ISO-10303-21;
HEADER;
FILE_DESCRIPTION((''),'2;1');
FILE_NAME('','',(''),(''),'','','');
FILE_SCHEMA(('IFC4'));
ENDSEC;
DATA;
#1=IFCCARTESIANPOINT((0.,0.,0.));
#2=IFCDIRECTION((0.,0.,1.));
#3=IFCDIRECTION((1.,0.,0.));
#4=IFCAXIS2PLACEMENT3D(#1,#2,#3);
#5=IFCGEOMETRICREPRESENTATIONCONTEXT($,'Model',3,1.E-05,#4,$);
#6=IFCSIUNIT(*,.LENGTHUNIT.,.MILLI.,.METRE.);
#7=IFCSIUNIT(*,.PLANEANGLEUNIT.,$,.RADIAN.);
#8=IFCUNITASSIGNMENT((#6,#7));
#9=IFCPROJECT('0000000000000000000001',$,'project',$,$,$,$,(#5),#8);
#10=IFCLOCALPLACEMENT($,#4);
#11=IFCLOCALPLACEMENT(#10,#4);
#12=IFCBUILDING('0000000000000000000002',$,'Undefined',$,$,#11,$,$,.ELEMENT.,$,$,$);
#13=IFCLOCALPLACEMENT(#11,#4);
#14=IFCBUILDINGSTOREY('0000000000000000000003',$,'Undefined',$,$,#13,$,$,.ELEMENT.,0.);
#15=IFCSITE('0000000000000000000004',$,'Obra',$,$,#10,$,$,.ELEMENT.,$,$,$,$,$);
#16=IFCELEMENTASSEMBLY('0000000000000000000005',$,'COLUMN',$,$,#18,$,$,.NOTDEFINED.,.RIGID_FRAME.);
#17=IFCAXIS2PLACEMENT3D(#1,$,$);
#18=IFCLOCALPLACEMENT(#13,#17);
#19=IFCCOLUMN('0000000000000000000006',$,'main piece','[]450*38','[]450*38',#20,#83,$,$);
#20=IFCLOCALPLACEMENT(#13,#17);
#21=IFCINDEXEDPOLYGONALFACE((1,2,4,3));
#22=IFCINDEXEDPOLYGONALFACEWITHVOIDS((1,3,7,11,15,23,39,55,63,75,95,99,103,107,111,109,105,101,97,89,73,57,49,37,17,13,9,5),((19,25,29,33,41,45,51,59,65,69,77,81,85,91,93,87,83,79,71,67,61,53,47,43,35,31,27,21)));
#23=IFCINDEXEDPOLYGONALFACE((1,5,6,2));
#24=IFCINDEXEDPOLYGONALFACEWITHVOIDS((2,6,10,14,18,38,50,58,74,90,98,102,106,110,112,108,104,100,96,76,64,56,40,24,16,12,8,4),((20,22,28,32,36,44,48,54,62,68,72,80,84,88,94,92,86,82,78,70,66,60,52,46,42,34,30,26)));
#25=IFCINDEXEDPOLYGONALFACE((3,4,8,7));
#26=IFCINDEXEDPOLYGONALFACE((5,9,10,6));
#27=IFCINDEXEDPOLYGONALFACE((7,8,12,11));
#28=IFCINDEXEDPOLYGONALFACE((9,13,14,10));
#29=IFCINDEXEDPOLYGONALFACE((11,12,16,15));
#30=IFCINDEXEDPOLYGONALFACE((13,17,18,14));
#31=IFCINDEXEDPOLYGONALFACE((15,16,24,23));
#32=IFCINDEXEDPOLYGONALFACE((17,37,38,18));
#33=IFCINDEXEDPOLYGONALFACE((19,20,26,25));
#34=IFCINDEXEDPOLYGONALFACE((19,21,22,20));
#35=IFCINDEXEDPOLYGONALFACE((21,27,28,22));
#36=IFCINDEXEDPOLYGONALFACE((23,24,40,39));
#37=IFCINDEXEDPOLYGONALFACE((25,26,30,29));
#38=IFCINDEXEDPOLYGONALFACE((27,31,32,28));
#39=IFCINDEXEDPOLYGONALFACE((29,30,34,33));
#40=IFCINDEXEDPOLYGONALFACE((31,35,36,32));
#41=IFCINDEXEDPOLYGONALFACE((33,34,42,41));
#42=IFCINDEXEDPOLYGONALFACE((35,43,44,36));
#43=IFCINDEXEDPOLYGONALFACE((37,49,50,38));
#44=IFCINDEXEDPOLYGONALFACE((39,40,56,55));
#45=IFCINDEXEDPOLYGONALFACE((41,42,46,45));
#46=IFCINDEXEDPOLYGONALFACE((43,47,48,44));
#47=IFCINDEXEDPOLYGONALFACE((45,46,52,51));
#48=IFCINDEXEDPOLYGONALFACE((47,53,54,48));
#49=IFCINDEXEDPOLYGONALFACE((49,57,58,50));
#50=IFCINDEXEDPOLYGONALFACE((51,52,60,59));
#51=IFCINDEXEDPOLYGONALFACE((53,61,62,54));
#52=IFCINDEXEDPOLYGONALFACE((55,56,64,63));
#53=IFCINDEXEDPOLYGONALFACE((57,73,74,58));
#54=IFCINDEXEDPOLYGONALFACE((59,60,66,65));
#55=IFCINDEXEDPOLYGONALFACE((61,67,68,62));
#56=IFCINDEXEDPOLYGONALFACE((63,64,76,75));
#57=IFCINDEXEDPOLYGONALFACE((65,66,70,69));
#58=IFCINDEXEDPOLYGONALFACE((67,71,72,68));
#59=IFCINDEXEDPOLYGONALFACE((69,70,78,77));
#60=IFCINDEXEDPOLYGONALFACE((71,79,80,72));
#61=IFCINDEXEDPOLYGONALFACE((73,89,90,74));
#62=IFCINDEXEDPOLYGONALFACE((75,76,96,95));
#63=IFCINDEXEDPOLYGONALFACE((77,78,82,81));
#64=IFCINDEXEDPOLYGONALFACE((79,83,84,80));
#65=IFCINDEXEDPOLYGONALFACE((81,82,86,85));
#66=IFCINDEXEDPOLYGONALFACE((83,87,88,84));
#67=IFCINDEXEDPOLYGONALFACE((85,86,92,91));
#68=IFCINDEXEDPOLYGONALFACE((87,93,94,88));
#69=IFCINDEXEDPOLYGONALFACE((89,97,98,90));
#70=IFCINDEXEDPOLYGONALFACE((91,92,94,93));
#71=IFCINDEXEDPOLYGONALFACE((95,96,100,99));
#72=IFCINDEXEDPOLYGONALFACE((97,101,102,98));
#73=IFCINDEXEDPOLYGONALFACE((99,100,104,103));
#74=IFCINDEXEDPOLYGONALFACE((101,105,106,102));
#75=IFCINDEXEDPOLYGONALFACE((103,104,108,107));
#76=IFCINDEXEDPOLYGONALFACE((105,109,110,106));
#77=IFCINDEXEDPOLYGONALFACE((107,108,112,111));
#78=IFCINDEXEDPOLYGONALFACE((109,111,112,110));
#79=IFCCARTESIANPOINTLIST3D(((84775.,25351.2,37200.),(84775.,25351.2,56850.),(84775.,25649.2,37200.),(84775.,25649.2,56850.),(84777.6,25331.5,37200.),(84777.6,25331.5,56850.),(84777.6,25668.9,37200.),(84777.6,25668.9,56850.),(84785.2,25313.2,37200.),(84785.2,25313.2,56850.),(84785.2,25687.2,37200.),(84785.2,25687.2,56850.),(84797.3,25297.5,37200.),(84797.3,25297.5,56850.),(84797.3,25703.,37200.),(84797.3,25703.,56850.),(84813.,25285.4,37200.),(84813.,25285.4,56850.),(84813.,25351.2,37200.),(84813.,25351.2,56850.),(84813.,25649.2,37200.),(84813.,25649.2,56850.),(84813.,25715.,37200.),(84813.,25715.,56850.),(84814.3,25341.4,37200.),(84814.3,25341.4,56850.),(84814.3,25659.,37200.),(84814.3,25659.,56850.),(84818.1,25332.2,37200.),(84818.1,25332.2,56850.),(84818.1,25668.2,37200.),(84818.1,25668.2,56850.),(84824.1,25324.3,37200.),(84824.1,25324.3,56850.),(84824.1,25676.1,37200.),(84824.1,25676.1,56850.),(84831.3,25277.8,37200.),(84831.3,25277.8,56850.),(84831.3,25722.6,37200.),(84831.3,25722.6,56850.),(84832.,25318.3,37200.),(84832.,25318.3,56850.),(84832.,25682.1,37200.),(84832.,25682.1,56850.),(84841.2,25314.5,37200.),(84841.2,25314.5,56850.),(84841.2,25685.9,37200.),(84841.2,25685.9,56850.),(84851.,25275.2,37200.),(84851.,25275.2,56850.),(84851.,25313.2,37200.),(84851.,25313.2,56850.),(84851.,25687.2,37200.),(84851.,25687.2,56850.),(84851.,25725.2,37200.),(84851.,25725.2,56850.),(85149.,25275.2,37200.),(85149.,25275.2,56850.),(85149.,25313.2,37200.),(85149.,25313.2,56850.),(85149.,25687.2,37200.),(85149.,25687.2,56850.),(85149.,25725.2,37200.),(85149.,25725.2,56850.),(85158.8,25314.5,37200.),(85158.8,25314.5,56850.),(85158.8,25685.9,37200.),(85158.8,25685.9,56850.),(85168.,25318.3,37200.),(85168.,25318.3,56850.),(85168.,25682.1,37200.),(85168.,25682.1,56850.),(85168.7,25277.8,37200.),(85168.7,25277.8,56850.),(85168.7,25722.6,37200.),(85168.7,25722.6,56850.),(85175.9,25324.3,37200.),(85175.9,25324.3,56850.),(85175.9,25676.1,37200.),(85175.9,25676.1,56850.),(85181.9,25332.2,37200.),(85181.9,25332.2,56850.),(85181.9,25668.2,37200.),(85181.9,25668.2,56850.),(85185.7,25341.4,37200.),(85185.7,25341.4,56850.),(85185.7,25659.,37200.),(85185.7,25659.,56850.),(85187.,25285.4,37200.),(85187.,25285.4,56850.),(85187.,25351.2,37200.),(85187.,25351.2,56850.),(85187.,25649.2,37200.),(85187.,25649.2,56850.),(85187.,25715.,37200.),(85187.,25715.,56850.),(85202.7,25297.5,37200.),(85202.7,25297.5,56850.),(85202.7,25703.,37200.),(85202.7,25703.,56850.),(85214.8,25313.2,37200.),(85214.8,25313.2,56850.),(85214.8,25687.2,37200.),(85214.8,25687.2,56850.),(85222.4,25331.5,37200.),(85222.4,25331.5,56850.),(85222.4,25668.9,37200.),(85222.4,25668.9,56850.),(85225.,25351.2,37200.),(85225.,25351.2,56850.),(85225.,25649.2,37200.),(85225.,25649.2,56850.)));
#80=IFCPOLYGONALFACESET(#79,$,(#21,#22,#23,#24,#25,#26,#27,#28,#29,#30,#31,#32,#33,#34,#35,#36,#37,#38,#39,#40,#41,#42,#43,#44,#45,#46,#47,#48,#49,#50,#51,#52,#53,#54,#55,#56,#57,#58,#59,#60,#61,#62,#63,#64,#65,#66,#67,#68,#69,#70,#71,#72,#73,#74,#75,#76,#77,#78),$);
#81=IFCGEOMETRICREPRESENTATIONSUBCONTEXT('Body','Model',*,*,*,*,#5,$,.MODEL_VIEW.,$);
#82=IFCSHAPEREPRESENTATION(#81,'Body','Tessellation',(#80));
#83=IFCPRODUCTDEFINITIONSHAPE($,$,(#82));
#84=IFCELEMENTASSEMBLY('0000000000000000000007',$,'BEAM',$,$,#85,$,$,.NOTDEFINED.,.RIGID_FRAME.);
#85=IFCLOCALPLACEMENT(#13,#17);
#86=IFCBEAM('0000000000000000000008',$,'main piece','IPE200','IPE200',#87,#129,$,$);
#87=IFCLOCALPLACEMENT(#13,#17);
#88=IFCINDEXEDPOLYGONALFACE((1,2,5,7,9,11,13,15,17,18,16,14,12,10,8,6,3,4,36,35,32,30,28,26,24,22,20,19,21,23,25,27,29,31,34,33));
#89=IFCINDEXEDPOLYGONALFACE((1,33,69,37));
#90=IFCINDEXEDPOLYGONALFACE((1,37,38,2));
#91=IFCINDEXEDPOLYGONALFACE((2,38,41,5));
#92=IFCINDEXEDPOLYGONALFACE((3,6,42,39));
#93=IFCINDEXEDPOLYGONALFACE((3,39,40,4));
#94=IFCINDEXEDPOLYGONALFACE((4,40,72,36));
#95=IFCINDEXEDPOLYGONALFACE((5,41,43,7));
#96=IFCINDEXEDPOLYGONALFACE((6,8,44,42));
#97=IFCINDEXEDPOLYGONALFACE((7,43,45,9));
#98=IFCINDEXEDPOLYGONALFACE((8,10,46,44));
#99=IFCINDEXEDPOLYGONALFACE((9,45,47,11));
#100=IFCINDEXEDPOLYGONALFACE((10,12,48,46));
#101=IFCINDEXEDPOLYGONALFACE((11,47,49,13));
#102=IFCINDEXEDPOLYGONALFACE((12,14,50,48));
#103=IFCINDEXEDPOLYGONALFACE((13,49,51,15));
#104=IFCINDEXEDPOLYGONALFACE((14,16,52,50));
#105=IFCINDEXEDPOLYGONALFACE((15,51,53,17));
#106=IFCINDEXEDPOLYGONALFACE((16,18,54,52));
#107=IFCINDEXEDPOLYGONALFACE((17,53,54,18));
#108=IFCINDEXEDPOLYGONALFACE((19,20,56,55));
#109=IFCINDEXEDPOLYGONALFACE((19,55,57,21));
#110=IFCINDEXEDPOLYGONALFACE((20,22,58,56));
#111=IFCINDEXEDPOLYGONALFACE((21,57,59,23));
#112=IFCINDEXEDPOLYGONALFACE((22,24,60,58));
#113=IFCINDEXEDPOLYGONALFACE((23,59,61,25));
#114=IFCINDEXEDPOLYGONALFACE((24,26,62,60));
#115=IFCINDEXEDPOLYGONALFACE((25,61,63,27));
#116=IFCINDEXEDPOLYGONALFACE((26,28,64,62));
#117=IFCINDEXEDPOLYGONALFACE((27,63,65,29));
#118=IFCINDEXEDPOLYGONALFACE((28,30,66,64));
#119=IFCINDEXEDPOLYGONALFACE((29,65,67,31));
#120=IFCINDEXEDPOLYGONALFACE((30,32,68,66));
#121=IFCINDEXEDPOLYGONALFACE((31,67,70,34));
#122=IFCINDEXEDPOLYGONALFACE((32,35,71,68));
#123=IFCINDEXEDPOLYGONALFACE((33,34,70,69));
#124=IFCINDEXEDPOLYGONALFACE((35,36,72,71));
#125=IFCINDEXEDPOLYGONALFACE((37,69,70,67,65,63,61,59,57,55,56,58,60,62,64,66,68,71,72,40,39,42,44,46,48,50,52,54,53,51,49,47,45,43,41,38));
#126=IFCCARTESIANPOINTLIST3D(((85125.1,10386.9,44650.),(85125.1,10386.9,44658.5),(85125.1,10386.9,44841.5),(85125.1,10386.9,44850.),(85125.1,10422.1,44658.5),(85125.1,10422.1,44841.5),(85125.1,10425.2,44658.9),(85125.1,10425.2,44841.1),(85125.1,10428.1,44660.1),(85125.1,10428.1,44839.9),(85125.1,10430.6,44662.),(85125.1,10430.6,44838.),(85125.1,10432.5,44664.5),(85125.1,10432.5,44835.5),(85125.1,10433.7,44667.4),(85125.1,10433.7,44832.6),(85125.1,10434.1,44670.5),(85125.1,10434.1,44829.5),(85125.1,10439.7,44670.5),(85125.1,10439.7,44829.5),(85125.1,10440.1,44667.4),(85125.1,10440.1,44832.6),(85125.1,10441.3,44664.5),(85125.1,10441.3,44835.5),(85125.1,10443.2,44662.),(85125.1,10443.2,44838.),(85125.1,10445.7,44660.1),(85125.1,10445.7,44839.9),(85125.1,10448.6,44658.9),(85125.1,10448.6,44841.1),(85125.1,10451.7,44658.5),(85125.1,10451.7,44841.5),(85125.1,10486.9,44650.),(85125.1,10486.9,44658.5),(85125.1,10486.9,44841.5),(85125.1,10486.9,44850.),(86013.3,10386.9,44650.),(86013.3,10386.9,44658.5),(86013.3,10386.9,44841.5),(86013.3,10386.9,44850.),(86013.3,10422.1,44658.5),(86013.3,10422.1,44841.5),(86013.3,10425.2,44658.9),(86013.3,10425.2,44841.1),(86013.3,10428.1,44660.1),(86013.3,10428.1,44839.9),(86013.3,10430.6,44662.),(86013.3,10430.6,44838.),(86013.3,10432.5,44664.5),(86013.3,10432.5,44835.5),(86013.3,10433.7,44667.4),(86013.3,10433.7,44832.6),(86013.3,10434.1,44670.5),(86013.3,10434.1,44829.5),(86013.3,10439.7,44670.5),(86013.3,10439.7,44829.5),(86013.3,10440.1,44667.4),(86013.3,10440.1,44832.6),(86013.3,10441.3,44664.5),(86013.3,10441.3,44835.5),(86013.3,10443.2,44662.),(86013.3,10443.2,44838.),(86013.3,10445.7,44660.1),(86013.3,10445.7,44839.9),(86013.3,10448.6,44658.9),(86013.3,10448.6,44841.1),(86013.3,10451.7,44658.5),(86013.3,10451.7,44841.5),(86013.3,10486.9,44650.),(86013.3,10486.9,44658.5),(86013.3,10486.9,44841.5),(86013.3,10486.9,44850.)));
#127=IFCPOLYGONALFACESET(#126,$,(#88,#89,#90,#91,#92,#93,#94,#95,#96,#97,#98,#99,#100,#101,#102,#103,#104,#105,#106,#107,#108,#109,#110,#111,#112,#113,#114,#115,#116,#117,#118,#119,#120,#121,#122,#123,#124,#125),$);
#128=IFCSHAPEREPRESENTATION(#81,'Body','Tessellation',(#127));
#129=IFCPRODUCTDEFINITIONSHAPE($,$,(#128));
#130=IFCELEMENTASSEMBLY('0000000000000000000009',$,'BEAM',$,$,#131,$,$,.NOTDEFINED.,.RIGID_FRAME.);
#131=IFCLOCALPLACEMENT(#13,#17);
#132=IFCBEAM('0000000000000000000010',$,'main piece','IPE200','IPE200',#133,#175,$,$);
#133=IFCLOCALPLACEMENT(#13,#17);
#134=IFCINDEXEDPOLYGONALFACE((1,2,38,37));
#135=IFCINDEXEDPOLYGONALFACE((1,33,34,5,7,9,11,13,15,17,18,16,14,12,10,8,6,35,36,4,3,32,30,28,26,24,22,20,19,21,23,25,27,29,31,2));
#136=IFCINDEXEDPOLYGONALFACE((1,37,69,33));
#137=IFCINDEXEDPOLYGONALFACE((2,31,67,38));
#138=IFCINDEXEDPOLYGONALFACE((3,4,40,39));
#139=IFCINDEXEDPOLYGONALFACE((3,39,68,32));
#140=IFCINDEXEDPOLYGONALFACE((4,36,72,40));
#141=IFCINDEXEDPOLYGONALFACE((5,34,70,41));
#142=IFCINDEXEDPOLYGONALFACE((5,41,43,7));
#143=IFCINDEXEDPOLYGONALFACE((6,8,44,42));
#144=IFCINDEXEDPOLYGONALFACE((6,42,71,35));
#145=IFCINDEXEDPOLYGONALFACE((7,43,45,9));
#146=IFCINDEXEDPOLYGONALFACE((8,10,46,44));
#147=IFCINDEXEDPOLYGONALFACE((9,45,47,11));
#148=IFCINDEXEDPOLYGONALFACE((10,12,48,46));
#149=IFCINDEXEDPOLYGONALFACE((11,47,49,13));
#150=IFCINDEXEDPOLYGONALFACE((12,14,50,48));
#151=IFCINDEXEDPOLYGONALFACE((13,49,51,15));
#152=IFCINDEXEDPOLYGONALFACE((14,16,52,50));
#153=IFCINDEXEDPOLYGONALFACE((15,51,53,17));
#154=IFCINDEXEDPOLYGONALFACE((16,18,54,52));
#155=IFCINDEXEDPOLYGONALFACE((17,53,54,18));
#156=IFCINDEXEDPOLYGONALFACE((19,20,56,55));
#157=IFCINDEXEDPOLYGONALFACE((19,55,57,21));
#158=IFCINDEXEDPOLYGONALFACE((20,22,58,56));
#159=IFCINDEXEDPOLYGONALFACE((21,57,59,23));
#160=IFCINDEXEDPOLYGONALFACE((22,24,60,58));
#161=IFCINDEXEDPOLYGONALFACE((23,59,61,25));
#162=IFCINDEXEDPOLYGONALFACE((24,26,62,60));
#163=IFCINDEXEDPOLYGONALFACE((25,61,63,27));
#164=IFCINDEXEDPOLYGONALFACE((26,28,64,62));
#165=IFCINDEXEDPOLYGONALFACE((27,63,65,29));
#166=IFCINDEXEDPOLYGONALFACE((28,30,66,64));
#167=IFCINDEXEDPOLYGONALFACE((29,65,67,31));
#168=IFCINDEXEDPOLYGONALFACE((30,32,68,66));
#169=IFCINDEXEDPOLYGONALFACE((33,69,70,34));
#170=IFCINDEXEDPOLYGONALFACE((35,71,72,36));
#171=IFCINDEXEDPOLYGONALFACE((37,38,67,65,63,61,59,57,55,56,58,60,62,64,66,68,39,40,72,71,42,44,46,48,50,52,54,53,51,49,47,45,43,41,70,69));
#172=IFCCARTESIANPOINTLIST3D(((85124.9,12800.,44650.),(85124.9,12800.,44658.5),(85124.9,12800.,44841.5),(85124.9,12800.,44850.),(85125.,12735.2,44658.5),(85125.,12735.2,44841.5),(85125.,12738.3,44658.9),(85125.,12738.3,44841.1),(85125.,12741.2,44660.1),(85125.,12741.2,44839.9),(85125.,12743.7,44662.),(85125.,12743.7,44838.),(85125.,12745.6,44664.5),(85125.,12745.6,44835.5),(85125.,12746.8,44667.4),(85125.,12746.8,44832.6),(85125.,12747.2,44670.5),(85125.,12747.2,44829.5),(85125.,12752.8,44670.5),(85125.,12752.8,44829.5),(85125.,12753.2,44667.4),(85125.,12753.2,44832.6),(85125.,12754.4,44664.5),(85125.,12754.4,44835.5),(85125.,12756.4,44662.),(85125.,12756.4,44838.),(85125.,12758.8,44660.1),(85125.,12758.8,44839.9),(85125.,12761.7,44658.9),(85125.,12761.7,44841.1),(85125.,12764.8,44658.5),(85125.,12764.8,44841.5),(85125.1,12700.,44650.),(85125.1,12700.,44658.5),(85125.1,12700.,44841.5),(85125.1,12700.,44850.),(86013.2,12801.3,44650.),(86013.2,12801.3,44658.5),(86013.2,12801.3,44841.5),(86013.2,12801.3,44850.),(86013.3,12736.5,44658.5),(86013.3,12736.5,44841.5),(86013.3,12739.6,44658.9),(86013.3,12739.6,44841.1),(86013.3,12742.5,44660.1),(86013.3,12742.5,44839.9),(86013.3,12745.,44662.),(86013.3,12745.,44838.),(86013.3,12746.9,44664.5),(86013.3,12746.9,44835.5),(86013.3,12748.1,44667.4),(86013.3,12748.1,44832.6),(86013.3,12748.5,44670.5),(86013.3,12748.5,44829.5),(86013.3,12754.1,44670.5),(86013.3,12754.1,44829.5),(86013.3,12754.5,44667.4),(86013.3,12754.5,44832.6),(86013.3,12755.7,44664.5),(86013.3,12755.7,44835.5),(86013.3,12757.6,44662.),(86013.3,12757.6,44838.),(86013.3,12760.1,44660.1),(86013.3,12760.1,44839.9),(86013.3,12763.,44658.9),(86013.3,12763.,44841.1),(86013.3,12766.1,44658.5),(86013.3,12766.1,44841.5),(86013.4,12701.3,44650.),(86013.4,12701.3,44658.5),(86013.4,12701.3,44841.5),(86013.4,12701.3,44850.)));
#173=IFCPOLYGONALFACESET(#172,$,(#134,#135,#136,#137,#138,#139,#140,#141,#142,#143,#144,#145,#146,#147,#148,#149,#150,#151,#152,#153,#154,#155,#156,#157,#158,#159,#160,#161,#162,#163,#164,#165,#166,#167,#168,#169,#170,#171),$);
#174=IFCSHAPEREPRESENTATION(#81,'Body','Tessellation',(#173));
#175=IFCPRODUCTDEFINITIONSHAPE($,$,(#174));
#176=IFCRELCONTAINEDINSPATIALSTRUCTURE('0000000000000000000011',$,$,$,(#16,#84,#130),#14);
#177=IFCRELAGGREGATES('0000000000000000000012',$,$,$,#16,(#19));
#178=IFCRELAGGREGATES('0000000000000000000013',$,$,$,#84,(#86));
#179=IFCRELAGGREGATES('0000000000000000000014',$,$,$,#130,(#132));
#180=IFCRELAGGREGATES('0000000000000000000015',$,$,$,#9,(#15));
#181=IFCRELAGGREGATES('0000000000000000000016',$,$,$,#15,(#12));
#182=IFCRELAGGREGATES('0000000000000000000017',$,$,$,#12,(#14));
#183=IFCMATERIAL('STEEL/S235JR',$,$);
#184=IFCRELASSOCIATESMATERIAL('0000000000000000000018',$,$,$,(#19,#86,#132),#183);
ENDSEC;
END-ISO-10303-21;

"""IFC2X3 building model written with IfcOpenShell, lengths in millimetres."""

from ifc_helpers import new_model, si_unit, frame, origin_with_axes, origin_2d_with_axis, place, context, subcontext, project, spatial, hollow_rectangle, i_section, extrude, material, element, aggregate, save


model = new_model("IFC2X3")

# Units and contexts
model_context = context("Model", 3, precision=1e-05, world=origin_with_axes())
body_context = subcontext(model_context, "Body", "Model", "MODEL_VIEW")
ifc_project = project(units=[si_unit("LENGTHUNIT", "METRE", prefix="MILLI"), si_unit("PLANEANGLEUNIT", "RADIAN")], contexts=[model_context])

# Site, building, storey
site_placement = place(None, origin_with_axes())
site = spatial("IfcSite", under=ifc_project, at=site_placement, Name="Obra", CompositionType="ELEMENT")
building_placement = place(site_placement, origin_with_axes())
building = spatial("IfcBuilding", under=site, at=building_placement, Name="Undefined", CompositionType="ELEMENT")
storey_placement = place(building_placement, origin_with_axes())
storey = spatial("IfcBuildingStorey", under=building, at=storey_placement, Name="Undefined", CompositionType="ELEMENT", Elevation=0.0)

# Element assembly, column
assembly_1_placement = place(storey_placement, origin_with_axes())
assembly_1 = element("IfcElementAssembly", 1, at=assembly_1_placement, inside=storey, Name="COLUMN", AssemblyPlace="NOTDEFINED", PredefinedType="RIGID_FRAME")
ifc_material = material(Name="STEEL/S235JR")
column_placement = place(assembly_1_placement, frame((85000.0, 25500.2, 37200.0), z_axis=(0.0, 0.0, 1.0), x_axis=(0.0, 1.0, 0.0)))
column = element("IfcColumn", 2, at=column_placement, material=ifc_material, Name="main piece", Description="[]450*38", ObjectType="[]450*38", context=body_context, shape_type="SweptSolid", body=[
    extrude(hollow_rectangle(XDim=450.0, YDim=450.0, WallThickness=38.0, InnerFilletRadius=38.0, OuterFilletRadius=76.0, at=origin_2d_with_axis()), frame((0.0, 0.0, 19650.0), z_axis=(0.0, 0.0, -1.0), x_axis=(0.0, 1.0, 0.0)), (0.0, 0.0, 1.0), 19650.0),
])
aggregate(assembly_1, [column])

# Element assemblies, beams
assembly_2_placement = place(storey_placement, origin_with_axes())
assembly_2 = element("IfcElementAssembly", 3, at=assembly_2_placement, inside=storey, Name="BEAM", AssemblyPlace="NOTDEFINED", PredefinedType="RIGID_FRAME")
beam_1_placement = place(assembly_2_placement, frame((85125.1, 10436.9, 44750.0), z_axis=(0.0, 0.0, 1.0), x_axis=(1.0, 0.0, 0.0)))
beam_1 = element("IfcBeam", 4, at=beam_1_placement, material=ifc_material, Name="main piece", Description="IPE200", ObjectType="IPE200", context=body_context, shape_type="SweptSolid", body=[
    extrude(i_section(OverallWidth=100.0, OverallDepth=200.0, WebThickness=5.6, FlangeThickness=8.5, FilletRadius=12.0, at=origin_2d_with_axis()), frame((888.2, 0.0, 0.0), z_axis=(-1.0, 0.0, 0.0), x_axis=(0.0, -1.0, 0.0)), (0.0, 0.0, 1.0), 888.2),
])
aggregate(assembly_2, [beam_1])
assembly_3_placement = place(storey_placement, origin_with_axes())
assembly_3 = element("IfcElementAssembly", 5, at=assembly_3_placement, inside=storey, Name="BEAM", AssemblyPlace="NOTDEFINED", PredefinedType="RIGID_FRAME")
beam_2_placement = place(assembly_3_placement, frame((85125.0, 12750.0, 44750.0), z_axis=(0.0, 0.0, 1.0), x_axis=(0.999999, 0.001449, 0.0)))
beam_2 = element("IfcBeam", 6, at=beam_2_placement, material=ifc_material, Name="main piece", Description="IPE200", ObjectType="IPE200", context=body_context, shape_type="SweptSolid", body=[
    extrude(i_section(OverallWidth=100.0, OverallDepth=200.0, WebThickness=5.6, FlangeThickness=8.5, FilletRadius=12.0, at=origin_2d_with_axis()), frame((888.3, 0.0, 0.0), z_axis=(-1.0, 0.0, 0.0), x_axis=(0.0, -1.0, 0.0)), (0.0, 0.0, 1.0), 888.3),
])
aggregate(assembly_3, [beam_2])

save(model, "model.ifc")
